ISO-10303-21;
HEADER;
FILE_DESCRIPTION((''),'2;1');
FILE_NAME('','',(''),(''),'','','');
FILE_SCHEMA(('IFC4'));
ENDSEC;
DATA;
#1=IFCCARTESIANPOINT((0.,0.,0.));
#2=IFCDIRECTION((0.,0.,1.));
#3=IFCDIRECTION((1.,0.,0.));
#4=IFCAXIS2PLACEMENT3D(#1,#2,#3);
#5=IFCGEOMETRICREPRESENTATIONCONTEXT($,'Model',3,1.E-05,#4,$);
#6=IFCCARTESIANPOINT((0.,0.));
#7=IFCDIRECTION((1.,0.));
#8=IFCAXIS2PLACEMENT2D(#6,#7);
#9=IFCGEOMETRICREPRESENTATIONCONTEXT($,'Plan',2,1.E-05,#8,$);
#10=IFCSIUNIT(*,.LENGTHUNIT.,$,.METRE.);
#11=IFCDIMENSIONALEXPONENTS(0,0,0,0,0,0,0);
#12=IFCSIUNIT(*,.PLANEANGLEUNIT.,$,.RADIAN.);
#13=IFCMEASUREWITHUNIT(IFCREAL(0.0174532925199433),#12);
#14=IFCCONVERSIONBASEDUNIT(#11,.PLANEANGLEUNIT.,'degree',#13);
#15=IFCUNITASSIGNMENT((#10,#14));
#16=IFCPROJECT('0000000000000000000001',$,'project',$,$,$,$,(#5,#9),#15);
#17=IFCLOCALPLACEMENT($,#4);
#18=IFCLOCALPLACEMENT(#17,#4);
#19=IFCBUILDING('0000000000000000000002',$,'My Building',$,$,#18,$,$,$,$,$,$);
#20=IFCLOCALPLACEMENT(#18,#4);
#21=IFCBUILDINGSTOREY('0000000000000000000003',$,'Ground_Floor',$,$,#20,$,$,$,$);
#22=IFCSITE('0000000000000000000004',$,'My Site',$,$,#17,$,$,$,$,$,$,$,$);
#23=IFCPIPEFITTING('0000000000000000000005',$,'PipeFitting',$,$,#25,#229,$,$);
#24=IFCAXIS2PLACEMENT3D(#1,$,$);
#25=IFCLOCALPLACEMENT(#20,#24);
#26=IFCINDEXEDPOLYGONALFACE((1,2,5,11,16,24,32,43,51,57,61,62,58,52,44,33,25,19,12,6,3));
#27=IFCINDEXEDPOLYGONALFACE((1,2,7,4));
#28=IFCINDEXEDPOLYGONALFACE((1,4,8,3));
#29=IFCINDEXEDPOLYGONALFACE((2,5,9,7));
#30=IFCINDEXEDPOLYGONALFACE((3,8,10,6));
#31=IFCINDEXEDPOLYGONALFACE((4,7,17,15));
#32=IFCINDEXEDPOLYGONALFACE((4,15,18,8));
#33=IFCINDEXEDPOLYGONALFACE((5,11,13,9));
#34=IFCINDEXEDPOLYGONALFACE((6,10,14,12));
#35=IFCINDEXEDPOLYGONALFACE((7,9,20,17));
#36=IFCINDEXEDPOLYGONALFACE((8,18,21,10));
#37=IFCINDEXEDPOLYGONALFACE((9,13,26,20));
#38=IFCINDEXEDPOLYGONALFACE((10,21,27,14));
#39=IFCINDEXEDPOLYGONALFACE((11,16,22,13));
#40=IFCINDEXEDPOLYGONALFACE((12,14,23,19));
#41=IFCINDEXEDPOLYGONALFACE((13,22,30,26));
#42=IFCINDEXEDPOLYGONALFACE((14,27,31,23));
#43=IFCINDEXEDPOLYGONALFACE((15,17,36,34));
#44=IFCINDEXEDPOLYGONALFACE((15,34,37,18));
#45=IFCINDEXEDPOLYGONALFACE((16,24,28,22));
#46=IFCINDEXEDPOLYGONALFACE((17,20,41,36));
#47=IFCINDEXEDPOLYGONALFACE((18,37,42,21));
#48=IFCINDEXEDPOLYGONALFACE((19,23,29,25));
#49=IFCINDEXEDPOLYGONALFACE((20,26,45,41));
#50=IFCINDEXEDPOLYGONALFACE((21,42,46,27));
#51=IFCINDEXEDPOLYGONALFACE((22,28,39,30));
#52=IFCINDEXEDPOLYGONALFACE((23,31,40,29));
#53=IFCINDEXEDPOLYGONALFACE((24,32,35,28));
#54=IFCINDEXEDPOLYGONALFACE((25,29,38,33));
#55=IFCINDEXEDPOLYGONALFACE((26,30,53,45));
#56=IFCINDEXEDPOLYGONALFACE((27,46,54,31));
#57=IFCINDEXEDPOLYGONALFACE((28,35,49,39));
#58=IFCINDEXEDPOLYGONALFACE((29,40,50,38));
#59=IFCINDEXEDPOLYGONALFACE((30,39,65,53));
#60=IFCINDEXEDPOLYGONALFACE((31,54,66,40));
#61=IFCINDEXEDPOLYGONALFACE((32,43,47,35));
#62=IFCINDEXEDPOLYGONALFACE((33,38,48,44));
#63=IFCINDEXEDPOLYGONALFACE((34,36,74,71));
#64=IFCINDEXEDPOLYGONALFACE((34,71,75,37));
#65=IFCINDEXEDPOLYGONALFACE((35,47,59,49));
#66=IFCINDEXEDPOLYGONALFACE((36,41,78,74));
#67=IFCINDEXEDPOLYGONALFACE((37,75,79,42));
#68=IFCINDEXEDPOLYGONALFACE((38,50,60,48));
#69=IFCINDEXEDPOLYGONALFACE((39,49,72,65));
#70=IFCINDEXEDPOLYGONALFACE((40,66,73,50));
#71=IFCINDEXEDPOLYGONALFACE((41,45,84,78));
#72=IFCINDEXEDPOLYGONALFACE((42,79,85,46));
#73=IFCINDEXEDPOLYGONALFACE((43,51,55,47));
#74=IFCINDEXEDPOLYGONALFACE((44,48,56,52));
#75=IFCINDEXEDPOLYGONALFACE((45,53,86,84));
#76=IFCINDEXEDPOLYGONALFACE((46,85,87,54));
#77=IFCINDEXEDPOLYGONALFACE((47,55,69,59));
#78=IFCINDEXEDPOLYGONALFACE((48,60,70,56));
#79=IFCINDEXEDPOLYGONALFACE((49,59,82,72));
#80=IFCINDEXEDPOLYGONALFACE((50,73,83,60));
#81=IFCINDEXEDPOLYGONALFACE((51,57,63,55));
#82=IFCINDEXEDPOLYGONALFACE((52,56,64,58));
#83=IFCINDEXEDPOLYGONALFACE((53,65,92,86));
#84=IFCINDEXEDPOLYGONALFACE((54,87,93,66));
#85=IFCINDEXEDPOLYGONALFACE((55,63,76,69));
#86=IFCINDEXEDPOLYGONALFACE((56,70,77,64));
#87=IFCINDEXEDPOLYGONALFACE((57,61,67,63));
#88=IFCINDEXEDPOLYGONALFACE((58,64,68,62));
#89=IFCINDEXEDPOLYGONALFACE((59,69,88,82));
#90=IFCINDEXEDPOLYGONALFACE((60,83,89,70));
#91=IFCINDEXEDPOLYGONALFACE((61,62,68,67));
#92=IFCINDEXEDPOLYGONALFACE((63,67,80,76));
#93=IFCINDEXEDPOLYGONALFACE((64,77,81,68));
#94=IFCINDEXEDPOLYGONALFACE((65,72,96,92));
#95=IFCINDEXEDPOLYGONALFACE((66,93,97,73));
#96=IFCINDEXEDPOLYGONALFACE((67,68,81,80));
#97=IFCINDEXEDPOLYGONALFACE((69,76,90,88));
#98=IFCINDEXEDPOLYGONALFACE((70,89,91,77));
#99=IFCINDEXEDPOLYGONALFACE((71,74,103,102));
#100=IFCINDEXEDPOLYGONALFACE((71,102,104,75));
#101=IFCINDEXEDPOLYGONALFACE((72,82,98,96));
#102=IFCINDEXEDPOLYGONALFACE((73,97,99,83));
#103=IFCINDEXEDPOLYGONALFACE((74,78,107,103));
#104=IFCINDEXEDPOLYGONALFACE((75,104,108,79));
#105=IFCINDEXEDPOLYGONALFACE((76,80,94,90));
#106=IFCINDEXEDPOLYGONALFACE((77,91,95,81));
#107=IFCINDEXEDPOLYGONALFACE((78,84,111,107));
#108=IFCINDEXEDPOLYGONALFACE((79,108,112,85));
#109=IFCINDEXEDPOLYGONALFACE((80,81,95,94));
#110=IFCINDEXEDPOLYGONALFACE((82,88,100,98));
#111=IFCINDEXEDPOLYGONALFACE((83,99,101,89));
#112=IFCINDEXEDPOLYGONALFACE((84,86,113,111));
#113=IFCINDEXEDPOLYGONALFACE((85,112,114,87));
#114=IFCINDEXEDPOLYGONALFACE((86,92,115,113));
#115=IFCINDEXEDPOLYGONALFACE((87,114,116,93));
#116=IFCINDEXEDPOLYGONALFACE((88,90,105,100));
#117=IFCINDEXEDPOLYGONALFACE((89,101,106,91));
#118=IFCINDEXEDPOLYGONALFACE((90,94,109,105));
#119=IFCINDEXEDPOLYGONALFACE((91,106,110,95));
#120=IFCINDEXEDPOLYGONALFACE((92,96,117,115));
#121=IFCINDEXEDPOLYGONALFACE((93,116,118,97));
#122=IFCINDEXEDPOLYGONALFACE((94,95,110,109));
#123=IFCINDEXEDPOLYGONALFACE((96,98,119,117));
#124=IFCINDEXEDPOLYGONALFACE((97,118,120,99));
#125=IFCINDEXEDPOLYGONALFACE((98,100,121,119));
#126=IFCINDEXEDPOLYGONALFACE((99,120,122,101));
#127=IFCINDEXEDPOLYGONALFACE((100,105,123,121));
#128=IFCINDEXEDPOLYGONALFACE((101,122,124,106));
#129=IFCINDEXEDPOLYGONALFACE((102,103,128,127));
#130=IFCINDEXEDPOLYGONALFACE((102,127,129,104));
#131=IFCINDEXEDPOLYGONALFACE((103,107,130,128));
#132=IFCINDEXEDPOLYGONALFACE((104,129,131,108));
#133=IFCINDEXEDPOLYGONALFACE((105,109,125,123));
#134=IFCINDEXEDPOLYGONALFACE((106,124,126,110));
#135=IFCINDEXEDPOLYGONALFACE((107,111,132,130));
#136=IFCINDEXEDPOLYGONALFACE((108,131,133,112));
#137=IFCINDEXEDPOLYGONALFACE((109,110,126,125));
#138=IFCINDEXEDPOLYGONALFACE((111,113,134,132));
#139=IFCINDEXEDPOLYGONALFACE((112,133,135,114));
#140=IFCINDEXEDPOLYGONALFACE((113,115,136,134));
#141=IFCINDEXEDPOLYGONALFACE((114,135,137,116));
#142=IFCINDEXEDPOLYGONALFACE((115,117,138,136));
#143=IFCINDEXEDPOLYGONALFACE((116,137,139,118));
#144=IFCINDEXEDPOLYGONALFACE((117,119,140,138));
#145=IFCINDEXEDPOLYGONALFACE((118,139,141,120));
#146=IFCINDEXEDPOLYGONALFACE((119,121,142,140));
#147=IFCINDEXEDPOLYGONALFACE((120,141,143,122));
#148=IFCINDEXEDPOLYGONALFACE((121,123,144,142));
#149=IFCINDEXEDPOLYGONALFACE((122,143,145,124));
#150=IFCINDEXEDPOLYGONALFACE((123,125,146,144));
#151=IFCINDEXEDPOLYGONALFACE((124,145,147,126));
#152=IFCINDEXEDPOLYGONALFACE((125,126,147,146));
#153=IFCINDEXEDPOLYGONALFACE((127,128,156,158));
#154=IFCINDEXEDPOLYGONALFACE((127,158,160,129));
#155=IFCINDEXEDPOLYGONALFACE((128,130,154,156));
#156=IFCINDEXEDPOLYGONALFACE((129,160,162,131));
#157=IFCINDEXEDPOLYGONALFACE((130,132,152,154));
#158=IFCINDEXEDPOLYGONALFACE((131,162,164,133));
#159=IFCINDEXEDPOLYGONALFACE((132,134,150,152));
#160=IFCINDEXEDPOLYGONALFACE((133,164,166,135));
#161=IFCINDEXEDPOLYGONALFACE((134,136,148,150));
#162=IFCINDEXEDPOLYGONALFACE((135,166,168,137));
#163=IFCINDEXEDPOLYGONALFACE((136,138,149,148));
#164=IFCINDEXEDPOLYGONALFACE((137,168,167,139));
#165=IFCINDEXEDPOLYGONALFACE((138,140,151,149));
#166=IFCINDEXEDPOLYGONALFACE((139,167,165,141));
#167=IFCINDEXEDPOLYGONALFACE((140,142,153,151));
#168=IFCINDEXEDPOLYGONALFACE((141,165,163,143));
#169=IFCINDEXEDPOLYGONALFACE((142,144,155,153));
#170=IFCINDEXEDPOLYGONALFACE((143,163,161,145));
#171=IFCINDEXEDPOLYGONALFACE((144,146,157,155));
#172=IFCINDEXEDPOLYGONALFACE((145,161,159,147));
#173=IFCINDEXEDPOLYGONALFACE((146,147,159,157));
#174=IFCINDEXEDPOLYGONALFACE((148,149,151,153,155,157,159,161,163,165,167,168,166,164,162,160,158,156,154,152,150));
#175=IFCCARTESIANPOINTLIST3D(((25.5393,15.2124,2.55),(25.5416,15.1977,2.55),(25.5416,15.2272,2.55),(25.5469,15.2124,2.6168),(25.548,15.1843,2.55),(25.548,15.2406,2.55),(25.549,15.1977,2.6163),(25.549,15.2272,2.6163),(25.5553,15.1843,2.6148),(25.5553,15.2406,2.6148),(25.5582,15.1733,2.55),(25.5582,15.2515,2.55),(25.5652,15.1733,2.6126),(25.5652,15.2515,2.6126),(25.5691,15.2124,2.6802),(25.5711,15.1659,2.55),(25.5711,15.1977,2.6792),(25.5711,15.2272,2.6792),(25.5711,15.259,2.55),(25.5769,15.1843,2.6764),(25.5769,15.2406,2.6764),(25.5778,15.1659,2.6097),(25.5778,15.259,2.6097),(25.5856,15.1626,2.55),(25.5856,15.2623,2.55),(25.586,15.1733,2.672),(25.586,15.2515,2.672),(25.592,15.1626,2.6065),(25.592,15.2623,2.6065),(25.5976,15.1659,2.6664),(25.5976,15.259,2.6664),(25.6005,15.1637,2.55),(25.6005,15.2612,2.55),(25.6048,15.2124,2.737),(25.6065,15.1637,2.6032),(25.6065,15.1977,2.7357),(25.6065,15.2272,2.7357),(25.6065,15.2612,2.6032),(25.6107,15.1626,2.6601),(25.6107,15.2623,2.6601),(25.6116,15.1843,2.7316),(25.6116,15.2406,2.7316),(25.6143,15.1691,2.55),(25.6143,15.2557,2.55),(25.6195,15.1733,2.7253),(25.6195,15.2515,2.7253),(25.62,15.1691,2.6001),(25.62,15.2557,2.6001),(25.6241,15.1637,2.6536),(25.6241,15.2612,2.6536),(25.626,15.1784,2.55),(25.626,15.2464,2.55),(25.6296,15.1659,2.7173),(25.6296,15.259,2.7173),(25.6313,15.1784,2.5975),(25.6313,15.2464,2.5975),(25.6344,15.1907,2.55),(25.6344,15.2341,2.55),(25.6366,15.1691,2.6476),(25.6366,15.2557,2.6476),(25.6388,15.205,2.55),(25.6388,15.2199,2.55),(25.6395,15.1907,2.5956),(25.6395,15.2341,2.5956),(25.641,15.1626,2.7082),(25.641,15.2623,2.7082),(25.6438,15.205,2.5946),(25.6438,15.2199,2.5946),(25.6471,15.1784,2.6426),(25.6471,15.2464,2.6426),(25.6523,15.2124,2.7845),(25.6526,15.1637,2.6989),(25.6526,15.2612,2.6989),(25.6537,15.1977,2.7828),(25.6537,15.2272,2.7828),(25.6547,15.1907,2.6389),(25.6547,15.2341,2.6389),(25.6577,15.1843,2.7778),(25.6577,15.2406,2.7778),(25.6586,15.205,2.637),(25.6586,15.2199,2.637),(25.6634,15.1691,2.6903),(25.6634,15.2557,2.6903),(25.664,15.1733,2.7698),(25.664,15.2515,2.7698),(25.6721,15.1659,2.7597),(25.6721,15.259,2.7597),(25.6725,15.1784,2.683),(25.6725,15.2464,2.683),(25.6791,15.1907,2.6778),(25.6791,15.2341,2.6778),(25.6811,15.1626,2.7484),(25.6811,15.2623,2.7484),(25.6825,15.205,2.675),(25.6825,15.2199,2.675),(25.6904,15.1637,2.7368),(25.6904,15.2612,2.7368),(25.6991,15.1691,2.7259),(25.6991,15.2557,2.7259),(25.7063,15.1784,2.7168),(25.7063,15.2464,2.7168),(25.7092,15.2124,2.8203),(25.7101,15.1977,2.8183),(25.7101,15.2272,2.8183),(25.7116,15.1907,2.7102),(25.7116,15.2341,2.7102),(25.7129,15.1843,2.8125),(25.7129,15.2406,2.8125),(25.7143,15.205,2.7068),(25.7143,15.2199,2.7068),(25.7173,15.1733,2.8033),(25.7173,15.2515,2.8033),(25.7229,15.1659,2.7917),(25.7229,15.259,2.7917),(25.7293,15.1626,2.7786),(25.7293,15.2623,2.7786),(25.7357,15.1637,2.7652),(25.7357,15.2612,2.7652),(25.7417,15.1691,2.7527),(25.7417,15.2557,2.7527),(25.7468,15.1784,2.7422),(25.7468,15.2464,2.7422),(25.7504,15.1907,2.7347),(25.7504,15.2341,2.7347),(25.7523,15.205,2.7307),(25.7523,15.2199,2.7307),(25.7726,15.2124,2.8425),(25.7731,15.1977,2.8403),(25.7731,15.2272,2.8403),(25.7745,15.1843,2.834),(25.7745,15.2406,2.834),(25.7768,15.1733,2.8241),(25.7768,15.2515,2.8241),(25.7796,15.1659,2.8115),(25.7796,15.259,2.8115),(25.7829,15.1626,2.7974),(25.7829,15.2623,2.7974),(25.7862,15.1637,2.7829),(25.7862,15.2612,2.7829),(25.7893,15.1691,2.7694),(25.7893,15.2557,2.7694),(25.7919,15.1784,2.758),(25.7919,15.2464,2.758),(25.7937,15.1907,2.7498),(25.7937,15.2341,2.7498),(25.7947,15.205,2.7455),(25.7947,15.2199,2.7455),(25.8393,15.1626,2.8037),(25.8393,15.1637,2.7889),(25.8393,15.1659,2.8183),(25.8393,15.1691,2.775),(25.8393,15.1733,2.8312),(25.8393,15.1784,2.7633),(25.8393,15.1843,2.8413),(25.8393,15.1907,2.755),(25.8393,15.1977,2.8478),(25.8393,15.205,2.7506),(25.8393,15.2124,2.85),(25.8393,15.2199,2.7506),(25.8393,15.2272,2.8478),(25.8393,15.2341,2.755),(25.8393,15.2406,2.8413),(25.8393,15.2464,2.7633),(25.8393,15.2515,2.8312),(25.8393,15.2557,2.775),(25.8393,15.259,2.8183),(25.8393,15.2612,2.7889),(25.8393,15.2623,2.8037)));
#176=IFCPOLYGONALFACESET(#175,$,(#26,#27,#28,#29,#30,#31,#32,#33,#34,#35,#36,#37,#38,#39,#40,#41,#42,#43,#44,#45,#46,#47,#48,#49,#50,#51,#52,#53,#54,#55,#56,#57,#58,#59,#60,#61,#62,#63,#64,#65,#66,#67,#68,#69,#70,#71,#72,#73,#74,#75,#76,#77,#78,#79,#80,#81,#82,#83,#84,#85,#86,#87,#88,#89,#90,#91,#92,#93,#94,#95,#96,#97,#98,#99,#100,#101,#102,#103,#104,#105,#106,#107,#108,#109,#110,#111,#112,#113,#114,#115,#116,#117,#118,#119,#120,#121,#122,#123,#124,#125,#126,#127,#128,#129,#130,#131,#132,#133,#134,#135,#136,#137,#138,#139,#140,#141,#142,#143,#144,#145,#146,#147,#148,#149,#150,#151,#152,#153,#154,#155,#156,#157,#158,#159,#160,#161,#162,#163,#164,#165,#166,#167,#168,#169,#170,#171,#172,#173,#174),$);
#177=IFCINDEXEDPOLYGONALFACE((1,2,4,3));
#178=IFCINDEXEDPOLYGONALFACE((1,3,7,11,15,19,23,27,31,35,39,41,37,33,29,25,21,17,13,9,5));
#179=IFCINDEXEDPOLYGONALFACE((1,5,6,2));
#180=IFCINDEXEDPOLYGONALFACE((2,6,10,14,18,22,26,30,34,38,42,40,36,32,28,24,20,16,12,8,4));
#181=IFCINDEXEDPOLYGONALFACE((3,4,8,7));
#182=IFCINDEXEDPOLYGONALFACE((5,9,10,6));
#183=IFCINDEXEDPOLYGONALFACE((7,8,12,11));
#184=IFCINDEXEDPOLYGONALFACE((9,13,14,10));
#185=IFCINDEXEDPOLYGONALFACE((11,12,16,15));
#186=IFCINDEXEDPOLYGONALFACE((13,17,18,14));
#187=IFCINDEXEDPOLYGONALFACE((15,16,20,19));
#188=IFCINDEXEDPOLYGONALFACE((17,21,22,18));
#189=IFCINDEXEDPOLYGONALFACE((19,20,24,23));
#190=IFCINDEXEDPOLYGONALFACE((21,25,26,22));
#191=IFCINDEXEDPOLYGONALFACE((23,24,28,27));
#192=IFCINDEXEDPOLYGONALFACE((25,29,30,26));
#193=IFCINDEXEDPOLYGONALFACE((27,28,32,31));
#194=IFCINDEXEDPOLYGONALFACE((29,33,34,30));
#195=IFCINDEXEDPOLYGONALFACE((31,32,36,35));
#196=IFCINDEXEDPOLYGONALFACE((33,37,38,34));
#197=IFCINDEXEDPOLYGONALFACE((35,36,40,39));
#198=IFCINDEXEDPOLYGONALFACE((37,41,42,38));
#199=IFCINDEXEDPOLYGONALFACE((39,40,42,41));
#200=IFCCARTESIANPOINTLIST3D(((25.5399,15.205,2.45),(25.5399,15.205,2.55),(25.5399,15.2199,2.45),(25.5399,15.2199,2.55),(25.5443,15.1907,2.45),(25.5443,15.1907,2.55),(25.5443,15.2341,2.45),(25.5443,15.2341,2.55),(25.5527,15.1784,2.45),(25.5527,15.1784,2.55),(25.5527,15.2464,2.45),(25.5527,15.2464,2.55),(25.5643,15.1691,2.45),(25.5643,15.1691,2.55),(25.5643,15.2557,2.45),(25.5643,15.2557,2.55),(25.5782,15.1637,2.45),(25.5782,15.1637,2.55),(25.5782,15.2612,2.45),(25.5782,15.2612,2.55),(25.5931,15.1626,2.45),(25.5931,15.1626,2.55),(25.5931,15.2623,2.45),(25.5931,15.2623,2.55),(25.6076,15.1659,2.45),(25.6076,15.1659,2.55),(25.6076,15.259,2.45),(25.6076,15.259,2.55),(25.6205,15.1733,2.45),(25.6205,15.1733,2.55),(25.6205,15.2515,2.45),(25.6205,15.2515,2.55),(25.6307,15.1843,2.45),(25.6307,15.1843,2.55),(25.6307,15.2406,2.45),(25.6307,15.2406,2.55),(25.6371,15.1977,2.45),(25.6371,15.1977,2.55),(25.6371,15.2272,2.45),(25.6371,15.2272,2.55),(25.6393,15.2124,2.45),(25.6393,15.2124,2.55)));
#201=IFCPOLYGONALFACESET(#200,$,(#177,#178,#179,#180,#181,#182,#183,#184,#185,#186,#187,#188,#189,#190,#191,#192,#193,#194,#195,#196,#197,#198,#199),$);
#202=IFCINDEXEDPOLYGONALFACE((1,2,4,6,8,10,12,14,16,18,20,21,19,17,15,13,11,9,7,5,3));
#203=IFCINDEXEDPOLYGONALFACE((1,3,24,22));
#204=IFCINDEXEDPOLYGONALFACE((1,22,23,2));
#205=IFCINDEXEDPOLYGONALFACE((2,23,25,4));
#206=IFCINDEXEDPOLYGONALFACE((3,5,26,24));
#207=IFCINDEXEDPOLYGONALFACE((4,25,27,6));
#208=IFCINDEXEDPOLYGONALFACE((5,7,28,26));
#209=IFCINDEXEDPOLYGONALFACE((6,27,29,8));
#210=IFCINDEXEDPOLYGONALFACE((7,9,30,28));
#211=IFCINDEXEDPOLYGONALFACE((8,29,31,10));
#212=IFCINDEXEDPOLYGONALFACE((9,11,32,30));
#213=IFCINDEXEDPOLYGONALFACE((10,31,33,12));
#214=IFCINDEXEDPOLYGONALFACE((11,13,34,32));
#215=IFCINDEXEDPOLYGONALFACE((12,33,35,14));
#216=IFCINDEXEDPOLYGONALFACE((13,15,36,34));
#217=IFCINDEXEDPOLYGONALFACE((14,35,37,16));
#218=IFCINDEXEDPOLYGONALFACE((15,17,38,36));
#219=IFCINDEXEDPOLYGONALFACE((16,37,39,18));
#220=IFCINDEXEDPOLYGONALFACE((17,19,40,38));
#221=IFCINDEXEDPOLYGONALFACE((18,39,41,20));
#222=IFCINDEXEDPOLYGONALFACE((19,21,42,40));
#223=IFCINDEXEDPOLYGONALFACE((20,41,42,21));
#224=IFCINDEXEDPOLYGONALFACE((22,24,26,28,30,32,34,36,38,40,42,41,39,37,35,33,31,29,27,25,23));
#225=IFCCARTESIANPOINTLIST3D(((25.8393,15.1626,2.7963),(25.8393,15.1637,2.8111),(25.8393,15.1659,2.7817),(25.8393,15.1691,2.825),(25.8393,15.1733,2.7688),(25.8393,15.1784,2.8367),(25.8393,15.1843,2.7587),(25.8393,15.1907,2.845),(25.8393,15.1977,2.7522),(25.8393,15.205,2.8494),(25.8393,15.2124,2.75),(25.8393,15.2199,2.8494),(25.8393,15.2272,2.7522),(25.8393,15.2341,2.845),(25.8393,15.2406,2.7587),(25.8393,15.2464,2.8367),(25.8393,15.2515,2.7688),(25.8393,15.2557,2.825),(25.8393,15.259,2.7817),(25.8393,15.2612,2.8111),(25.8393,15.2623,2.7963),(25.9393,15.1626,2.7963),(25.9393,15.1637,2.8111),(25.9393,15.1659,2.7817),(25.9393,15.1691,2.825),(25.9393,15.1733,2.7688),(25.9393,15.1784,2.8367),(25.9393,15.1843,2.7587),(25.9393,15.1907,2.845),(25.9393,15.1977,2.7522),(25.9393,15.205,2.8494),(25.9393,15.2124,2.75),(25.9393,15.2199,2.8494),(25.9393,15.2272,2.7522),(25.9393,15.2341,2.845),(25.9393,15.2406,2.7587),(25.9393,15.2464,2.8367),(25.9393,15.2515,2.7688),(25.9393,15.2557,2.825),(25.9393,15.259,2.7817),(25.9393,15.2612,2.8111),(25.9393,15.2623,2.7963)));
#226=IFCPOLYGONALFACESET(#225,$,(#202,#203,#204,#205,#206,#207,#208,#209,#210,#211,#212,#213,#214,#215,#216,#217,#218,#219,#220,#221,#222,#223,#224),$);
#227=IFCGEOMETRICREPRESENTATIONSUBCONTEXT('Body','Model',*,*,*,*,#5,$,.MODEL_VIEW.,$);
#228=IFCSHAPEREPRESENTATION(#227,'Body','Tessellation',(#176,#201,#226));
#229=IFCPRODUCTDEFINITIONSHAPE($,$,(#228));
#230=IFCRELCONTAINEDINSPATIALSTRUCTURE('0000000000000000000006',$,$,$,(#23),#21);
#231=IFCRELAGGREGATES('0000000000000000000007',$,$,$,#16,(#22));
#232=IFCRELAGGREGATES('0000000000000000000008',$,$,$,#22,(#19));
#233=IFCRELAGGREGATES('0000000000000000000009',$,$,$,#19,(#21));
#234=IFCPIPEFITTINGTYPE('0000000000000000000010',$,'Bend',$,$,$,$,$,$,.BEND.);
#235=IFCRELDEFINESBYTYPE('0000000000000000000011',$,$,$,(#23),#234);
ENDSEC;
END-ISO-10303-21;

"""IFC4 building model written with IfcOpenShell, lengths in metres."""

from ifc_helpers import new_model, entity, si_unit, converted_unit, frame, origin_with_axes, origin_2d_with_axis, place, context, subcontext, project, spatial, circle, extrude, source, transform, mapped, type_object, type_shapes, element, save


model = new_model("IFC4")

# Units and contexts
model_context = context("Model", 3, precision=1e-05, world=origin_with_axes())
plan_context = context("Plan", 2, precision=1e-05, world=origin_2d_with_axis())
body_context = subcontext(model_context, "Body", "Model", "MODEL_VIEW")
ifc_project = project(units=[si_unit("LENGTHUNIT", "METRE"), converted_unit("PLANEANGLEUNIT", "degree", entity("IfcReal", 0.0174532925199433), si_unit("PLANEANGLEUNIT", "RADIAN"), dimensions=[0, 0, 0, 0, 0, 0, 0])], contexts=[model_context, plan_context])

# Site, building, storey
site_placement = place(None, origin_with_axes())
site = spatial("IfcSite", under=ifc_project, at=site_placement, Name="My Site")
building_placement = place(site_placement, origin_with_axes())
building = spatial("IfcBuilding", under=site, at=building_placement, Name="My Building")
storey_placement = place(building_placement, origin_with_axes())
storey = spatial("IfcBuildingStorey", under=building, at=storey_placement, Name="Ground_Floor")

# Pipe fitting
pipe_fitting_type = type_object("IfcPipeFittingType", Name="Bend", PredefinedType="BEND")
shared_shape = source(origin_with_axes(), body_context, "Body", "SolidModel", [
    entity("IfcSweptDiskSolid", entity("IfcIndexedPolyCurve", entity("IfcCartesianPointList3D", [[0.0, 0.0, -0.1], [0.0732, 0.0, -0.2768], [0.25, 0.0, -0.35]]), [entity("IfcArcIndex", [1, 2, 3])]), 0.05),
    extrude(circle(Radius=0.05), origin_with_axes(), (0.0, 0.0, -1.0), 0.1),
    extrude(circle(Radius=0.05), frame((0.25, 0.0, -0.35), z_axis=(1.0, 0.0, 0.0), x_axis=(0.0, 0.0, 1.0)), (0.0, 0.0, 1.0), 0.1),
])
type_shapes(pipe_fitting_type, [shared_shape])
for number, where, z_axis, x_axis, name in (
    (1, (25.5893, 15.2124, 2.45), (0.0, 0.0, -1.0), (1.0, 0.0, 0.0), "PipeFitting"),
):
    element("IfcPipeFitting", number, at=place(storey_placement, frame(where, z_axis=z_axis, x_axis=x_axis)), inside=storey, type_object=pipe_fitting_type, Name=name, context=body_context, shape_type="MappedRepresentation", body=[
        mapped(shared_shape, transform((0.0, 0.0, 0.0), x_axis=(1.0, 0.0, 0.0), y_axis=(0.0, 1.0, 0.0), z_axis=(0.0, 0.0, 1.0), scale=1.0)),
    ])

save(model, "model.ifc")
